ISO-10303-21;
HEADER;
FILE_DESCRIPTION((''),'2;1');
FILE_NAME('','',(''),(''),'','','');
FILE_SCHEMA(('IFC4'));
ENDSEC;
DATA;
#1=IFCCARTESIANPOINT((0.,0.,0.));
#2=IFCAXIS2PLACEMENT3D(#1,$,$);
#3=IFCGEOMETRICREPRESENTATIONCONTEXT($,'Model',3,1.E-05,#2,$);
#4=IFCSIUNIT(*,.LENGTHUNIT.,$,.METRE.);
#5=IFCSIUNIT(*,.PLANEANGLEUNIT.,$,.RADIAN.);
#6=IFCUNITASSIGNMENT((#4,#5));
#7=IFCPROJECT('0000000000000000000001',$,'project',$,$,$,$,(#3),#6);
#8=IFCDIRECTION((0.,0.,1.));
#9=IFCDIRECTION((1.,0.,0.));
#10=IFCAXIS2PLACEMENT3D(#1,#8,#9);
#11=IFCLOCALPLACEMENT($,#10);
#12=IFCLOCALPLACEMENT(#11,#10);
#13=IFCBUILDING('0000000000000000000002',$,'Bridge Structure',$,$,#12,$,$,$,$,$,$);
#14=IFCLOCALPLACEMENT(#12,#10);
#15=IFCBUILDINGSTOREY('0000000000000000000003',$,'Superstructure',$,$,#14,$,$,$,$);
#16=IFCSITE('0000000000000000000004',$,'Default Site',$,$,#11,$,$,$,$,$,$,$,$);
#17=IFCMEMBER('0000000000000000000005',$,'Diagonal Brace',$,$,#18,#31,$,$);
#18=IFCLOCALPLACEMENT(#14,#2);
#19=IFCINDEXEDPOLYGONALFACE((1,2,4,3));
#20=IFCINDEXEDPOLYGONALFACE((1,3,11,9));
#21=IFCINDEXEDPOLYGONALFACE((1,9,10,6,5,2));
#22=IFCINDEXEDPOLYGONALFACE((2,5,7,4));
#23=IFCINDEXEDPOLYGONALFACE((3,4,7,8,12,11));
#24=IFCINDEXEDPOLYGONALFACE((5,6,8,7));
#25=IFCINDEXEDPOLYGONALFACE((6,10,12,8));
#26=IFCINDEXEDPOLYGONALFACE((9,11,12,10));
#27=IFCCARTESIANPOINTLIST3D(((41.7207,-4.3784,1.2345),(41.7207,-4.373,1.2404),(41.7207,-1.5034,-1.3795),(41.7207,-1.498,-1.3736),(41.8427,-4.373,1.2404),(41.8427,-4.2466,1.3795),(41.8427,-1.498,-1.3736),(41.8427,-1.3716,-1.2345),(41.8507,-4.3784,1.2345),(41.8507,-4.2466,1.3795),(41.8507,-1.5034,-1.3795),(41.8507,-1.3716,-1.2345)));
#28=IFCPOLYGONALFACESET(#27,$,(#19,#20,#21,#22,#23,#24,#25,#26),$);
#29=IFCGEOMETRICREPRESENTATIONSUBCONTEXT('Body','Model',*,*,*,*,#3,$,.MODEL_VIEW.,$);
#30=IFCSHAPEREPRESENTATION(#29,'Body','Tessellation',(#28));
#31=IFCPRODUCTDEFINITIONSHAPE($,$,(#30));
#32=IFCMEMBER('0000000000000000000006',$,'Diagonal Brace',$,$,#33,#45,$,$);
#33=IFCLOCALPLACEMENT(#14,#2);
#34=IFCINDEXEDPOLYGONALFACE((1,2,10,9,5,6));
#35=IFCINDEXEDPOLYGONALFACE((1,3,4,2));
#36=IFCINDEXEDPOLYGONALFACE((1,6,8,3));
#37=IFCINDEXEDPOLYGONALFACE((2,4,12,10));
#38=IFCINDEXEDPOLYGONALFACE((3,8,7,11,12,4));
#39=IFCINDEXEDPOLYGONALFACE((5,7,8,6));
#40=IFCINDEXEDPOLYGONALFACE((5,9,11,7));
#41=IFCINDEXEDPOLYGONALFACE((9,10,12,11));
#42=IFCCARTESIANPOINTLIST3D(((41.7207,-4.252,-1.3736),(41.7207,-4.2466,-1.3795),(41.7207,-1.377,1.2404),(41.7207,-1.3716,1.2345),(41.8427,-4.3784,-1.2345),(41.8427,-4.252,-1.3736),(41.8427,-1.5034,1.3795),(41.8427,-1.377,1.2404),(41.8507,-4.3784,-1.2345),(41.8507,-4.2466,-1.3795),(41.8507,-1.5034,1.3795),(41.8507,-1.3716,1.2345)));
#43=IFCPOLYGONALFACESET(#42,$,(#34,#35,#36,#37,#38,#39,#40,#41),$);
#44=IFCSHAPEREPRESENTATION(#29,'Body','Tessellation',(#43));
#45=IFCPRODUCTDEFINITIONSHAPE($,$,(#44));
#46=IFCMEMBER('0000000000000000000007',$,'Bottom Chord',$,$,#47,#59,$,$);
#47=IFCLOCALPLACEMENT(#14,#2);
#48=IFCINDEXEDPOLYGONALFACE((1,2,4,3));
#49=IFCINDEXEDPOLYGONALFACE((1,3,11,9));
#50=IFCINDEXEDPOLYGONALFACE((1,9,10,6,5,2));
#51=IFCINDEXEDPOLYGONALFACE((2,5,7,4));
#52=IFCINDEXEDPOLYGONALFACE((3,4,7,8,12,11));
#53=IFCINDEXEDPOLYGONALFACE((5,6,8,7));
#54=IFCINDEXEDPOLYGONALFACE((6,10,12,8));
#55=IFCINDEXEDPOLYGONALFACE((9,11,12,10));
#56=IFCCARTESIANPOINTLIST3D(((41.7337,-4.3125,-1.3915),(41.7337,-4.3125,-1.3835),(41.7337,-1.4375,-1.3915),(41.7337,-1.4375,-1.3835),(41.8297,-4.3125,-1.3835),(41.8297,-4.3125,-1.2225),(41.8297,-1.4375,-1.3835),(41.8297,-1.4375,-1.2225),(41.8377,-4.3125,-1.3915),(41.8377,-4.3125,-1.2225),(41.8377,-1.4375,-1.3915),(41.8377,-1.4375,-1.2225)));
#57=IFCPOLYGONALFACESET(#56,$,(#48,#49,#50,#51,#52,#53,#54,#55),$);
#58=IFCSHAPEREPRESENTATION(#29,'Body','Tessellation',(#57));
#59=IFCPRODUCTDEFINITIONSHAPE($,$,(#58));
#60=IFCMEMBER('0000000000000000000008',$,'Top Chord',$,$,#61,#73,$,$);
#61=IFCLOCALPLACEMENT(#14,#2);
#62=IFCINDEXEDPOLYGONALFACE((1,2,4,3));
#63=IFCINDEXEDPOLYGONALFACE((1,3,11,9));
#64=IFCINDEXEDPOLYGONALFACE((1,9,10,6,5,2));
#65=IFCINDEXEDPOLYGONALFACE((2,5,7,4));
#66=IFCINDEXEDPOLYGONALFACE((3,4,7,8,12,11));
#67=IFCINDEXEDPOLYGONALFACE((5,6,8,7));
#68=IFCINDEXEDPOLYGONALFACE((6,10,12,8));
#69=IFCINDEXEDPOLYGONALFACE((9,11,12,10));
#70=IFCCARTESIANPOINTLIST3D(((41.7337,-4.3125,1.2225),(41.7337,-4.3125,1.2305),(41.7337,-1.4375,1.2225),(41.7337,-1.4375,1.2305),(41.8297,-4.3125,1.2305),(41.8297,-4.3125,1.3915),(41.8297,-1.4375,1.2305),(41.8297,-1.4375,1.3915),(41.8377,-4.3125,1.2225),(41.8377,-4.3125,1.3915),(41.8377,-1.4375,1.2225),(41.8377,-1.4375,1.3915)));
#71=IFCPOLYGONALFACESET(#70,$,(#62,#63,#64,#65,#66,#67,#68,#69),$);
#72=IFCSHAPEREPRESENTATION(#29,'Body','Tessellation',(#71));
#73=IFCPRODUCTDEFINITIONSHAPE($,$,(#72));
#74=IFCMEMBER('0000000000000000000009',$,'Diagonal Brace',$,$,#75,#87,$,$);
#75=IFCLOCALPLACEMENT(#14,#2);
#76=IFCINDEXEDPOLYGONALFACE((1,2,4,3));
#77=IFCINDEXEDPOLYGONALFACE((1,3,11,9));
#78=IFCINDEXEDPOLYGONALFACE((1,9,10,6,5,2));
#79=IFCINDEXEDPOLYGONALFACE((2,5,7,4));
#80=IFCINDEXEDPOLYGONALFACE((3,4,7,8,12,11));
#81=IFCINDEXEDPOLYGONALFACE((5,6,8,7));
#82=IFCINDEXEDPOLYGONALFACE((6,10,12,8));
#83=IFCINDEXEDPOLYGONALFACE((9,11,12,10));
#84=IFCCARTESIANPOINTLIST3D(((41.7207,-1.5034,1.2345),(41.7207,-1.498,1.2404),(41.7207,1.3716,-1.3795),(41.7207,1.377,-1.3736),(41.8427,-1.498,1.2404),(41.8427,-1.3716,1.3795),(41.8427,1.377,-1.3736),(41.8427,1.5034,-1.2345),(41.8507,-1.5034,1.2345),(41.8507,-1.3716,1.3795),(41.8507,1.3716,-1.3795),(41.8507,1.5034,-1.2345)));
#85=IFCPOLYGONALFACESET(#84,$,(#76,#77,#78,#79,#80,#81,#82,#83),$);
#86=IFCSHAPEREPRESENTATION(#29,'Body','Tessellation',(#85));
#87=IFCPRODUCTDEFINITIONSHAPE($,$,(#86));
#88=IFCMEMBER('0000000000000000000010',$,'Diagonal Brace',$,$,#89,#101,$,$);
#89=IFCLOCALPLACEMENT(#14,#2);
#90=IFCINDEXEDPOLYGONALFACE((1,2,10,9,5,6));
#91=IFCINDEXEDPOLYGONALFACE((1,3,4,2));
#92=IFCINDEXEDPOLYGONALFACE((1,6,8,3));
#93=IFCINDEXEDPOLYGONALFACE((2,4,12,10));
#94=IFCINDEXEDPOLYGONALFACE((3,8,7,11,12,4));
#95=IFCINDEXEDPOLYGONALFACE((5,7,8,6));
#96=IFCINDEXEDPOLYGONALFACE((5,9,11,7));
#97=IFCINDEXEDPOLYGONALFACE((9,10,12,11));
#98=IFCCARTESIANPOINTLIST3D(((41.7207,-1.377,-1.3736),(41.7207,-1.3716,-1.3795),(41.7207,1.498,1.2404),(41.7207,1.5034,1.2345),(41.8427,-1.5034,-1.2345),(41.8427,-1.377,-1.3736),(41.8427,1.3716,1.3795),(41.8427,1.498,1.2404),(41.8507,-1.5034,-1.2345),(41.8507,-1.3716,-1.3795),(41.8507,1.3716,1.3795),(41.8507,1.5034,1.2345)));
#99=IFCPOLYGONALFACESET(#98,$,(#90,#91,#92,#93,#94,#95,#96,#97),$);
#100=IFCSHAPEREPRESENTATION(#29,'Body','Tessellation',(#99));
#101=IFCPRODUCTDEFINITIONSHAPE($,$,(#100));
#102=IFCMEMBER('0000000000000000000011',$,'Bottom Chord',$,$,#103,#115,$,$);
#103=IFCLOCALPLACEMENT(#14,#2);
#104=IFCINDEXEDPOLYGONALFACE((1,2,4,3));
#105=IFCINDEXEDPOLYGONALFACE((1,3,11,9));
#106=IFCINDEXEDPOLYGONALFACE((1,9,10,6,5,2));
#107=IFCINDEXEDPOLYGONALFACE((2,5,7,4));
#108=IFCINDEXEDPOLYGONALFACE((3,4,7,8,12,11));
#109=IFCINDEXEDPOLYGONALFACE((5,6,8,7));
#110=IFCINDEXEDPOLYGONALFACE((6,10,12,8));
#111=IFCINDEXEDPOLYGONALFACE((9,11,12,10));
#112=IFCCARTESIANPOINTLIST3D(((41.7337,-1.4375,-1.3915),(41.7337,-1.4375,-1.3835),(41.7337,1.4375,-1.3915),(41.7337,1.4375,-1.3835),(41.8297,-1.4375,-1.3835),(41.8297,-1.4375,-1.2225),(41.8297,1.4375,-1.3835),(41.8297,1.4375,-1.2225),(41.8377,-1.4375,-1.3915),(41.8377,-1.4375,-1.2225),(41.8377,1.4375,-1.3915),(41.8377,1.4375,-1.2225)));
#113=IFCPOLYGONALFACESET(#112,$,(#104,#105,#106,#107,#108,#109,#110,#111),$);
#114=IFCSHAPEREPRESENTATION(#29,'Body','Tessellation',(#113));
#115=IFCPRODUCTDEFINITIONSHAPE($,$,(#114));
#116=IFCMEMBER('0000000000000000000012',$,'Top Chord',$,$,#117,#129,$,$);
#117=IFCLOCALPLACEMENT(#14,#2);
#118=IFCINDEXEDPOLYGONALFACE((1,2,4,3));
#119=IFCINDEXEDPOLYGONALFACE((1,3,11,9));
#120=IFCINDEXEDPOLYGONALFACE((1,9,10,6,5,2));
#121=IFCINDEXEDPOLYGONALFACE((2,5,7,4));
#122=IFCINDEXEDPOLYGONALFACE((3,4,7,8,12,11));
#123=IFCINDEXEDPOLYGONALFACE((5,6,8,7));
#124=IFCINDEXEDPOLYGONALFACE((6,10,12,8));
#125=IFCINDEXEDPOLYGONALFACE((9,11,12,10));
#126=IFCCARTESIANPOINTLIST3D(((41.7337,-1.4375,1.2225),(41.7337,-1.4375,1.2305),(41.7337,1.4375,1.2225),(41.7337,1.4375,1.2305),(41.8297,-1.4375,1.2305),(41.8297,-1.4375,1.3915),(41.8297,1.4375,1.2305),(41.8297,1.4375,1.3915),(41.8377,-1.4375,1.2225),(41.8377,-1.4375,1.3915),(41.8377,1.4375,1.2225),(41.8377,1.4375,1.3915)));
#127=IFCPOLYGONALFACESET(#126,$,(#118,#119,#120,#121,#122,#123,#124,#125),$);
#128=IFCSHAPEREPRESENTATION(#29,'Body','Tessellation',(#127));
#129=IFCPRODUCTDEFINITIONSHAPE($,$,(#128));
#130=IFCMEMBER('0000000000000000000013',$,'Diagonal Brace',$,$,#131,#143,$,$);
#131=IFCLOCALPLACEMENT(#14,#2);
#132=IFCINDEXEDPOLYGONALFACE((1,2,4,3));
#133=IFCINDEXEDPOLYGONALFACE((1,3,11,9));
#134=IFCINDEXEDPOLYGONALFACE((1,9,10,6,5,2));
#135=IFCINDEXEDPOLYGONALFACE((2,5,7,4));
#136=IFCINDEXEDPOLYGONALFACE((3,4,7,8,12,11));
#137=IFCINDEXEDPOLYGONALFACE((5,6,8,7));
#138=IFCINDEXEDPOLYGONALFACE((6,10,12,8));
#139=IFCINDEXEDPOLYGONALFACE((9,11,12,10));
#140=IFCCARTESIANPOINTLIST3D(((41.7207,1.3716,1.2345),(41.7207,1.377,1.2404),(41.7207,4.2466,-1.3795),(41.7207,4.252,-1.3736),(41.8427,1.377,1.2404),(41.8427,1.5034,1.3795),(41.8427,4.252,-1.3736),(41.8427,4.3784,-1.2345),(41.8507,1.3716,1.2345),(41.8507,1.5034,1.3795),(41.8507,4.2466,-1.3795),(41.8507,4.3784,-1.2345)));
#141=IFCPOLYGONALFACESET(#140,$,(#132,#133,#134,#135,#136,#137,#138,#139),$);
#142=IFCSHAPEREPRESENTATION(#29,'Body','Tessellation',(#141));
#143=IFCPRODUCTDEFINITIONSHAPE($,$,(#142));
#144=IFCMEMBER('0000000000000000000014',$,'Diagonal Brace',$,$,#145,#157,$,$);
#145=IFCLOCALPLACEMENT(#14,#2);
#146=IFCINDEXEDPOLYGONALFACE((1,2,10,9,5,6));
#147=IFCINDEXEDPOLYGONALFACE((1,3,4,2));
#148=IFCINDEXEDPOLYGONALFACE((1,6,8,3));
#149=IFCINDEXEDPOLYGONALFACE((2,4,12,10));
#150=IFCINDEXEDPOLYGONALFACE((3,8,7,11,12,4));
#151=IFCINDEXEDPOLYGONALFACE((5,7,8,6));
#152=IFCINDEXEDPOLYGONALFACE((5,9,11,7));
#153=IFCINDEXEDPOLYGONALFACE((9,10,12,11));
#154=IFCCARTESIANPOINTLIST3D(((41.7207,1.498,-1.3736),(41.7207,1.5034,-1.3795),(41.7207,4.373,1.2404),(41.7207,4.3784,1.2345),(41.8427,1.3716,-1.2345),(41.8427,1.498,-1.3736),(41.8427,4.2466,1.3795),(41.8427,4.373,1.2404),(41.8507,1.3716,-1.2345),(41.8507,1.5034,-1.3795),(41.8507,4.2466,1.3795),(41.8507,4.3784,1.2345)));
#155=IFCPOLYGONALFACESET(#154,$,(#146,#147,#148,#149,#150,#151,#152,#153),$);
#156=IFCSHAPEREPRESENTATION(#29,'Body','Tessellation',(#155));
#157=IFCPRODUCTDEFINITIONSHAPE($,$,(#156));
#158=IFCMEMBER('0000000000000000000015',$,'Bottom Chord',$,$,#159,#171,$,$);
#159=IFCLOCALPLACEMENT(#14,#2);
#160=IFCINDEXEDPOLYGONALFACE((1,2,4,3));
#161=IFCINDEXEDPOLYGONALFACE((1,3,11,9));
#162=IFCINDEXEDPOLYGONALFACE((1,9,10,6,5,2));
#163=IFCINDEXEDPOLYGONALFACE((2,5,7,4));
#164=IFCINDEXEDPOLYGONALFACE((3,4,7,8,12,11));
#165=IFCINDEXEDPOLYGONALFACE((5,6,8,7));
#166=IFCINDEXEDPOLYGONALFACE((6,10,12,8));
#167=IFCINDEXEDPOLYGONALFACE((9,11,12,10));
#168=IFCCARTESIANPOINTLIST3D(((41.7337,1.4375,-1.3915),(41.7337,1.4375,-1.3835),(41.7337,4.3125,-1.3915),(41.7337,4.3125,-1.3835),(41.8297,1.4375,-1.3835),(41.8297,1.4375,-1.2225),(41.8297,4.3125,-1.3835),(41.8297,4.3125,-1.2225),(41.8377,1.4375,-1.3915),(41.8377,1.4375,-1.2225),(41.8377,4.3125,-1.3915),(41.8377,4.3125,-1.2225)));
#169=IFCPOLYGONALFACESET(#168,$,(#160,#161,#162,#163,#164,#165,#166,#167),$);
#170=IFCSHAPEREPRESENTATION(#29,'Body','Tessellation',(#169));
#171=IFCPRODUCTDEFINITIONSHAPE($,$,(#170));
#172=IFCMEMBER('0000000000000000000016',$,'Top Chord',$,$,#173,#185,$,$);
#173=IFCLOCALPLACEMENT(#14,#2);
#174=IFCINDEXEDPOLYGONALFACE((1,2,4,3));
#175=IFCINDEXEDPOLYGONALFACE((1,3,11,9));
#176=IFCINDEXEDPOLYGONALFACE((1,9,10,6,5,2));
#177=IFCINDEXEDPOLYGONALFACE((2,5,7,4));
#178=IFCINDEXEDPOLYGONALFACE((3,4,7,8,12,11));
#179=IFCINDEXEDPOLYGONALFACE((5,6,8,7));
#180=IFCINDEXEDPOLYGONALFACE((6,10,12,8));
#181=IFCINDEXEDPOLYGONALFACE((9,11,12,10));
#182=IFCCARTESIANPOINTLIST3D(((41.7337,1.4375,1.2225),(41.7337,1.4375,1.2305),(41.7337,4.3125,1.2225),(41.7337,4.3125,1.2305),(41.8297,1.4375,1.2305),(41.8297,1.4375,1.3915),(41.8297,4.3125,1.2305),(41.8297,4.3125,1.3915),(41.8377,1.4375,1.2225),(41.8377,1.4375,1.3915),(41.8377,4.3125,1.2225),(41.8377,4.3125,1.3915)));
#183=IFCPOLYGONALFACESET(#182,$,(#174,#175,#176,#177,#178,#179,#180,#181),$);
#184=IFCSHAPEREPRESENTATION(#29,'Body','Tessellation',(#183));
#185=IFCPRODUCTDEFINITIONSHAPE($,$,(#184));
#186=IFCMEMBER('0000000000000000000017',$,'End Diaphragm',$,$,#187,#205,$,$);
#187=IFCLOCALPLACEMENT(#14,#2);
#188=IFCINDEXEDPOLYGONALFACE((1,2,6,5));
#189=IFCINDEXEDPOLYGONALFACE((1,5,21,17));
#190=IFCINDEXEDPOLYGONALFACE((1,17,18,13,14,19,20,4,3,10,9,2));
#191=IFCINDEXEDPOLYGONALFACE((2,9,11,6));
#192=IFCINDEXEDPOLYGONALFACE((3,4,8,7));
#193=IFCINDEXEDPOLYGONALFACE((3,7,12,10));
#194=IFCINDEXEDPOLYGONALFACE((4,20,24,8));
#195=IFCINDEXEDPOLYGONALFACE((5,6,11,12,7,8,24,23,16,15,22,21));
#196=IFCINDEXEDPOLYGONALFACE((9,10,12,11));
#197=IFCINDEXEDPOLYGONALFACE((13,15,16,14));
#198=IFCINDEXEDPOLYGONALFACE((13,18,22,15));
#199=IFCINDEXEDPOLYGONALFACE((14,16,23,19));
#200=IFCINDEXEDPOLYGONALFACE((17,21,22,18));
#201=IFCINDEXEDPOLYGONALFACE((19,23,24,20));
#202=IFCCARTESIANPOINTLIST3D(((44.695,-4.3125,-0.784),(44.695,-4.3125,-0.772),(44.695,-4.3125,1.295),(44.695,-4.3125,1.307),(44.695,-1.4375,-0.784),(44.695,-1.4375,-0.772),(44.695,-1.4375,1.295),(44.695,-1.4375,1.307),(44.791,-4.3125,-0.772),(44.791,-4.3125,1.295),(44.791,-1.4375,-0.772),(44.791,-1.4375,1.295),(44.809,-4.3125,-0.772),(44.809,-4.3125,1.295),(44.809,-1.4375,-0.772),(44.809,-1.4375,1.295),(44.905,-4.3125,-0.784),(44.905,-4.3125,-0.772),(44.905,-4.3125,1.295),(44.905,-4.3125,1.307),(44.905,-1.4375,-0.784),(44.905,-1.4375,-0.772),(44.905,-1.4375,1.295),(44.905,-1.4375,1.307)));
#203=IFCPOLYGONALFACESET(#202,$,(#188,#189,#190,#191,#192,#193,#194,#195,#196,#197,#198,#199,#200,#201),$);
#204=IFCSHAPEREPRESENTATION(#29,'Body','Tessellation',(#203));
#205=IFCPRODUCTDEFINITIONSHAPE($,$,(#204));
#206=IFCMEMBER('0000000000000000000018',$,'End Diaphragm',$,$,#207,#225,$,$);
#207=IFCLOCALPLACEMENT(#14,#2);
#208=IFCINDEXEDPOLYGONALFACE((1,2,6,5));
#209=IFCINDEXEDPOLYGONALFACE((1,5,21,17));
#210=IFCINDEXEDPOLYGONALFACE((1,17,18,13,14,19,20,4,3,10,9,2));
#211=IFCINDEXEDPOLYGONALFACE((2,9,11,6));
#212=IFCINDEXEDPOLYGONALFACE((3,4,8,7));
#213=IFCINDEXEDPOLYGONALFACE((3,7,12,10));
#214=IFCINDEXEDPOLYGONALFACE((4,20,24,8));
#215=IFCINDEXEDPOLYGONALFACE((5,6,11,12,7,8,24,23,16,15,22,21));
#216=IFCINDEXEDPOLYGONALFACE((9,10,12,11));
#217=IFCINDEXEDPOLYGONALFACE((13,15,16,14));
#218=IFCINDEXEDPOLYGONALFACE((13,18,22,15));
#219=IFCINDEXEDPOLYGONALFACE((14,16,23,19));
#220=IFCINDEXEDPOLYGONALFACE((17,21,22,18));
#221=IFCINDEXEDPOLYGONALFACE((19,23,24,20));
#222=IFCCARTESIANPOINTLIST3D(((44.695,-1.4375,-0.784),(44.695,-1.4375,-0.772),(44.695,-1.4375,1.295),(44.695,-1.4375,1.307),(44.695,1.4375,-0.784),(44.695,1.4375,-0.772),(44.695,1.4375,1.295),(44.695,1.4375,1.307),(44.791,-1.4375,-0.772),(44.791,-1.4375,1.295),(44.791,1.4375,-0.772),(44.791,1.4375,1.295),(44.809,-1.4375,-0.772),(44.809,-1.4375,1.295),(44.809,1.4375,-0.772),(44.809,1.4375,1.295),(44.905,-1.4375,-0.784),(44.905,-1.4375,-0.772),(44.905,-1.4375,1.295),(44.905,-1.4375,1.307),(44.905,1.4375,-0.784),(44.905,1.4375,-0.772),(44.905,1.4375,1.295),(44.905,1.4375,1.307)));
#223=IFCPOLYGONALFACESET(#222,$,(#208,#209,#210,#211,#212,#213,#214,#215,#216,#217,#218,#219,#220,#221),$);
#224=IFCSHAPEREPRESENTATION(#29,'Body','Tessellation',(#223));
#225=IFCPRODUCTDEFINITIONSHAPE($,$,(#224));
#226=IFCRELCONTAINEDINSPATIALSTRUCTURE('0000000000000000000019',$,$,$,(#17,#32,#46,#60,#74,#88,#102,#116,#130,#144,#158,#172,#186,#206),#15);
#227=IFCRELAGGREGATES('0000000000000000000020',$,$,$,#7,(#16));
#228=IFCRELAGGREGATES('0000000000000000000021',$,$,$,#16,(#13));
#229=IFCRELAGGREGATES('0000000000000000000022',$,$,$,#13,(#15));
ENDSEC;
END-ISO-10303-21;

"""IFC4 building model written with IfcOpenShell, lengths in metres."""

from ifc_helpers import new_model, si_unit, frame, origin, origin_with_axes, origin_2d_with_axis, place, context, subcontext, project, spatial, i_section, l_section, extrude, element, save


model = new_model("IFC4")

# Units and contexts
model_context = context("Model", 3, precision=1e-05, world=origin())
body_context = subcontext(model_context, "Body", "Model", "MODEL_VIEW")
ifc_project = project(units=[si_unit("LENGTHUNIT", "METRE"), si_unit("PLANEANGLEUNIT", "RADIAN")], contexts=[model_context])

# Site, building, storey
site_placement = place(None, origin_with_axes())
site = spatial("IfcSite", under=ifc_project, at=site_placement, Name="Default Site")
building_placement = place(site_placement, origin_with_axes())
building = spatial("IfcBuilding", under=site, at=building_placement, Name="Bridge Structure")
storey_placement = place(building_placement, origin_with_axes())
storey = spatial("IfcBuildingStorey", under=building, at=storey_placement, Name="Superstructure")

# Members
for number, where, z_axis, x_axis, name in (
    (1, (41.7857, -4.3125, 1.307), (0.0, 0.739893, -0.672724), (-1.0, 0.0, 0.0), "Diagonal Brace"),
    (2, (41.7857, -4.3125, -1.307), (0.0, 0.739893, 0.672724), (-1.0, 0.0, 0.0), "Diagonal Brace"),
):
    element("IfcMember", number, at=place(storey_placement, frame(where, z_axis=z_axis, x_axis=x_axis)), inside=storey, Name=name, context=body_context, shape_type="SweptSolid", body=[
        extrude(l_section(Depth=0.196, Width=0.13, Thickness=0.008, at=origin_2d_with_axis()), origin_with_axes(), (0.0, 0.0, 1.0), 3.8857),
    ])
for number, where, z_axis, x_axis, name in (
    (3, (41.7857, -4.3125, -1.307), (0.0, 1.0, 0.0), (-1.0, 0.0, 0.0), "Bottom Chord"),
    (4, (41.7857, -4.3125, 1.307), (0.0, 1.0, 0.0), (-1.0, 0.0, 0.0), "Top Chord"),
):
    element("IfcMember", number, at=place(storey_placement, frame(where, z_axis=z_axis, x_axis=x_axis)), inside=storey, Name=name, context=body_context, shape_type="SweptSolid", body=[
        extrude(l_section(Depth=0.169, Width=0.104, Thickness=0.008, at=origin_2d_with_axis()), origin_with_axes(), (0.0, 0.0, 1.0), 2.875),
    ])
for number, where, z_axis, x_axis, name in (
    (5, (41.7857, -1.4375, 1.307), (0.0, 0.739893, -0.672724), (-1.0, 0.0, 0.0), "Diagonal Brace"),
    (6, (41.7857, -1.4375, -1.307), (0.0, 0.739893, 0.672724), (-1.0, 0.0, 0.0), "Diagonal Brace"),
):
    element("IfcMember", number, at=place(storey_placement, frame(where, z_axis=z_axis, x_axis=x_axis)), inside=storey, Name=name, context=body_context, shape_type="SweptSolid", body=[
        extrude(l_section(Depth=0.196, Width=0.13, Thickness=0.008, at=origin_2d_with_axis()), origin_with_axes(), (0.0, 0.0, 1.0), 3.8857),
    ])
for number, where, z_axis, x_axis, name in (
    (7, (41.7857, -1.4375, -1.307), (0.0, 1.0, 0.0), (-1.0, 0.0, 0.0), "Bottom Chord"),
    (8, (41.7857, -1.4375, 1.307), (0.0, 1.0, 0.0), (-1.0, 0.0, 0.0), "Top Chord"),
):
    element("IfcMember", number, at=place(storey_placement, frame(where, z_axis=z_axis, x_axis=x_axis)), inside=storey, Name=name, context=body_context, shape_type="SweptSolid", body=[
        extrude(l_section(Depth=0.169, Width=0.104, Thickness=0.008, at=origin_2d_with_axis()), origin_with_axes(), (0.0, 0.0, 1.0), 2.875),
    ])
for number, where, z_axis, x_axis, name in (
    (9, (41.7857, 1.4375, 1.307), (0.0, 0.739893, -0.672724), (-1.0, 0.0, 0.0), "Diagonal Brace"),
    (10, (41.7857, 1.4375, -1.307), (0.0, 0.739893, 0.672724), (-1.0, 0.0, 0.0), "Diagonal Brace"),
):
    element("IfcMember", number, at=place(storey_placement, frame(where, z_axis=z_axis, x_axis=x_axis)), inside=storey, Name=name, context=body_context, shape_type="SweptSolid", body=[
        extrude(l_section(Depth=0.196, Width=0.13, Thickness=0.008, at=origin_2d_with_axis()), origin_with_axes(), (0.0, 0.0, 1.0), 3.8857),
    ])
for number, where, z_axis, x_axis, name in (
    (11, (41.7857, 1.4375, -1.307), (0.0, 1.0, 0.0), (-1.0, 0.0, 0.0), "Bottom Chord"),
    (12, (41.7857, 1.4375, 1.307), (0.0, 1.0, 0.0), (-1.0, 0.0, 0.0), "Top Chord"),
):
    element("IfcMember", number, at=place(storey_placement, frame(where, z_axis=z_axis, x_axis=x_axis)), inside=storey, Name=name, context=body_context, shape_type="SweptSolid", body=[
        extrude(l_section(Depth=0.169, Width=0.104, Thickness=0.008, at=origin_2d_with_axis()), origin_with_axes(), (0.0, 0.0, 1.0), 2.875),
    ])
for number, where, z_axis, x_axis, name in (
    (13, (44.8, -4.3125, 0.2615), (0.0, 1.0, 0.0), (-1.0, 0.0, 0.0), "End Diaphragm"),
    (14, (44.8, -1.4375, 0.2615), (0.0, 1.0, 0.0), (-1.0, 0.0, 0.0), "End Diaphragm"),
):
    element("IfcMember", number, at=place(storey_placement, frame(where, z_axis=z_axis, x_axis=x_axis)), inside=storey, Name=name, context=body_context, shape_type="SweptSolid", body=[
        extrude(i_section(OverallWidth=0.21, OverallDepth=2.091, WebThickness=0.018, FlangeThickness=0.012, at=origin_2d_with_axis()), origin_with_axes(), (0.0, 0.0, 1.0), 2.875),
    ])

save(model, "model.ifc")
